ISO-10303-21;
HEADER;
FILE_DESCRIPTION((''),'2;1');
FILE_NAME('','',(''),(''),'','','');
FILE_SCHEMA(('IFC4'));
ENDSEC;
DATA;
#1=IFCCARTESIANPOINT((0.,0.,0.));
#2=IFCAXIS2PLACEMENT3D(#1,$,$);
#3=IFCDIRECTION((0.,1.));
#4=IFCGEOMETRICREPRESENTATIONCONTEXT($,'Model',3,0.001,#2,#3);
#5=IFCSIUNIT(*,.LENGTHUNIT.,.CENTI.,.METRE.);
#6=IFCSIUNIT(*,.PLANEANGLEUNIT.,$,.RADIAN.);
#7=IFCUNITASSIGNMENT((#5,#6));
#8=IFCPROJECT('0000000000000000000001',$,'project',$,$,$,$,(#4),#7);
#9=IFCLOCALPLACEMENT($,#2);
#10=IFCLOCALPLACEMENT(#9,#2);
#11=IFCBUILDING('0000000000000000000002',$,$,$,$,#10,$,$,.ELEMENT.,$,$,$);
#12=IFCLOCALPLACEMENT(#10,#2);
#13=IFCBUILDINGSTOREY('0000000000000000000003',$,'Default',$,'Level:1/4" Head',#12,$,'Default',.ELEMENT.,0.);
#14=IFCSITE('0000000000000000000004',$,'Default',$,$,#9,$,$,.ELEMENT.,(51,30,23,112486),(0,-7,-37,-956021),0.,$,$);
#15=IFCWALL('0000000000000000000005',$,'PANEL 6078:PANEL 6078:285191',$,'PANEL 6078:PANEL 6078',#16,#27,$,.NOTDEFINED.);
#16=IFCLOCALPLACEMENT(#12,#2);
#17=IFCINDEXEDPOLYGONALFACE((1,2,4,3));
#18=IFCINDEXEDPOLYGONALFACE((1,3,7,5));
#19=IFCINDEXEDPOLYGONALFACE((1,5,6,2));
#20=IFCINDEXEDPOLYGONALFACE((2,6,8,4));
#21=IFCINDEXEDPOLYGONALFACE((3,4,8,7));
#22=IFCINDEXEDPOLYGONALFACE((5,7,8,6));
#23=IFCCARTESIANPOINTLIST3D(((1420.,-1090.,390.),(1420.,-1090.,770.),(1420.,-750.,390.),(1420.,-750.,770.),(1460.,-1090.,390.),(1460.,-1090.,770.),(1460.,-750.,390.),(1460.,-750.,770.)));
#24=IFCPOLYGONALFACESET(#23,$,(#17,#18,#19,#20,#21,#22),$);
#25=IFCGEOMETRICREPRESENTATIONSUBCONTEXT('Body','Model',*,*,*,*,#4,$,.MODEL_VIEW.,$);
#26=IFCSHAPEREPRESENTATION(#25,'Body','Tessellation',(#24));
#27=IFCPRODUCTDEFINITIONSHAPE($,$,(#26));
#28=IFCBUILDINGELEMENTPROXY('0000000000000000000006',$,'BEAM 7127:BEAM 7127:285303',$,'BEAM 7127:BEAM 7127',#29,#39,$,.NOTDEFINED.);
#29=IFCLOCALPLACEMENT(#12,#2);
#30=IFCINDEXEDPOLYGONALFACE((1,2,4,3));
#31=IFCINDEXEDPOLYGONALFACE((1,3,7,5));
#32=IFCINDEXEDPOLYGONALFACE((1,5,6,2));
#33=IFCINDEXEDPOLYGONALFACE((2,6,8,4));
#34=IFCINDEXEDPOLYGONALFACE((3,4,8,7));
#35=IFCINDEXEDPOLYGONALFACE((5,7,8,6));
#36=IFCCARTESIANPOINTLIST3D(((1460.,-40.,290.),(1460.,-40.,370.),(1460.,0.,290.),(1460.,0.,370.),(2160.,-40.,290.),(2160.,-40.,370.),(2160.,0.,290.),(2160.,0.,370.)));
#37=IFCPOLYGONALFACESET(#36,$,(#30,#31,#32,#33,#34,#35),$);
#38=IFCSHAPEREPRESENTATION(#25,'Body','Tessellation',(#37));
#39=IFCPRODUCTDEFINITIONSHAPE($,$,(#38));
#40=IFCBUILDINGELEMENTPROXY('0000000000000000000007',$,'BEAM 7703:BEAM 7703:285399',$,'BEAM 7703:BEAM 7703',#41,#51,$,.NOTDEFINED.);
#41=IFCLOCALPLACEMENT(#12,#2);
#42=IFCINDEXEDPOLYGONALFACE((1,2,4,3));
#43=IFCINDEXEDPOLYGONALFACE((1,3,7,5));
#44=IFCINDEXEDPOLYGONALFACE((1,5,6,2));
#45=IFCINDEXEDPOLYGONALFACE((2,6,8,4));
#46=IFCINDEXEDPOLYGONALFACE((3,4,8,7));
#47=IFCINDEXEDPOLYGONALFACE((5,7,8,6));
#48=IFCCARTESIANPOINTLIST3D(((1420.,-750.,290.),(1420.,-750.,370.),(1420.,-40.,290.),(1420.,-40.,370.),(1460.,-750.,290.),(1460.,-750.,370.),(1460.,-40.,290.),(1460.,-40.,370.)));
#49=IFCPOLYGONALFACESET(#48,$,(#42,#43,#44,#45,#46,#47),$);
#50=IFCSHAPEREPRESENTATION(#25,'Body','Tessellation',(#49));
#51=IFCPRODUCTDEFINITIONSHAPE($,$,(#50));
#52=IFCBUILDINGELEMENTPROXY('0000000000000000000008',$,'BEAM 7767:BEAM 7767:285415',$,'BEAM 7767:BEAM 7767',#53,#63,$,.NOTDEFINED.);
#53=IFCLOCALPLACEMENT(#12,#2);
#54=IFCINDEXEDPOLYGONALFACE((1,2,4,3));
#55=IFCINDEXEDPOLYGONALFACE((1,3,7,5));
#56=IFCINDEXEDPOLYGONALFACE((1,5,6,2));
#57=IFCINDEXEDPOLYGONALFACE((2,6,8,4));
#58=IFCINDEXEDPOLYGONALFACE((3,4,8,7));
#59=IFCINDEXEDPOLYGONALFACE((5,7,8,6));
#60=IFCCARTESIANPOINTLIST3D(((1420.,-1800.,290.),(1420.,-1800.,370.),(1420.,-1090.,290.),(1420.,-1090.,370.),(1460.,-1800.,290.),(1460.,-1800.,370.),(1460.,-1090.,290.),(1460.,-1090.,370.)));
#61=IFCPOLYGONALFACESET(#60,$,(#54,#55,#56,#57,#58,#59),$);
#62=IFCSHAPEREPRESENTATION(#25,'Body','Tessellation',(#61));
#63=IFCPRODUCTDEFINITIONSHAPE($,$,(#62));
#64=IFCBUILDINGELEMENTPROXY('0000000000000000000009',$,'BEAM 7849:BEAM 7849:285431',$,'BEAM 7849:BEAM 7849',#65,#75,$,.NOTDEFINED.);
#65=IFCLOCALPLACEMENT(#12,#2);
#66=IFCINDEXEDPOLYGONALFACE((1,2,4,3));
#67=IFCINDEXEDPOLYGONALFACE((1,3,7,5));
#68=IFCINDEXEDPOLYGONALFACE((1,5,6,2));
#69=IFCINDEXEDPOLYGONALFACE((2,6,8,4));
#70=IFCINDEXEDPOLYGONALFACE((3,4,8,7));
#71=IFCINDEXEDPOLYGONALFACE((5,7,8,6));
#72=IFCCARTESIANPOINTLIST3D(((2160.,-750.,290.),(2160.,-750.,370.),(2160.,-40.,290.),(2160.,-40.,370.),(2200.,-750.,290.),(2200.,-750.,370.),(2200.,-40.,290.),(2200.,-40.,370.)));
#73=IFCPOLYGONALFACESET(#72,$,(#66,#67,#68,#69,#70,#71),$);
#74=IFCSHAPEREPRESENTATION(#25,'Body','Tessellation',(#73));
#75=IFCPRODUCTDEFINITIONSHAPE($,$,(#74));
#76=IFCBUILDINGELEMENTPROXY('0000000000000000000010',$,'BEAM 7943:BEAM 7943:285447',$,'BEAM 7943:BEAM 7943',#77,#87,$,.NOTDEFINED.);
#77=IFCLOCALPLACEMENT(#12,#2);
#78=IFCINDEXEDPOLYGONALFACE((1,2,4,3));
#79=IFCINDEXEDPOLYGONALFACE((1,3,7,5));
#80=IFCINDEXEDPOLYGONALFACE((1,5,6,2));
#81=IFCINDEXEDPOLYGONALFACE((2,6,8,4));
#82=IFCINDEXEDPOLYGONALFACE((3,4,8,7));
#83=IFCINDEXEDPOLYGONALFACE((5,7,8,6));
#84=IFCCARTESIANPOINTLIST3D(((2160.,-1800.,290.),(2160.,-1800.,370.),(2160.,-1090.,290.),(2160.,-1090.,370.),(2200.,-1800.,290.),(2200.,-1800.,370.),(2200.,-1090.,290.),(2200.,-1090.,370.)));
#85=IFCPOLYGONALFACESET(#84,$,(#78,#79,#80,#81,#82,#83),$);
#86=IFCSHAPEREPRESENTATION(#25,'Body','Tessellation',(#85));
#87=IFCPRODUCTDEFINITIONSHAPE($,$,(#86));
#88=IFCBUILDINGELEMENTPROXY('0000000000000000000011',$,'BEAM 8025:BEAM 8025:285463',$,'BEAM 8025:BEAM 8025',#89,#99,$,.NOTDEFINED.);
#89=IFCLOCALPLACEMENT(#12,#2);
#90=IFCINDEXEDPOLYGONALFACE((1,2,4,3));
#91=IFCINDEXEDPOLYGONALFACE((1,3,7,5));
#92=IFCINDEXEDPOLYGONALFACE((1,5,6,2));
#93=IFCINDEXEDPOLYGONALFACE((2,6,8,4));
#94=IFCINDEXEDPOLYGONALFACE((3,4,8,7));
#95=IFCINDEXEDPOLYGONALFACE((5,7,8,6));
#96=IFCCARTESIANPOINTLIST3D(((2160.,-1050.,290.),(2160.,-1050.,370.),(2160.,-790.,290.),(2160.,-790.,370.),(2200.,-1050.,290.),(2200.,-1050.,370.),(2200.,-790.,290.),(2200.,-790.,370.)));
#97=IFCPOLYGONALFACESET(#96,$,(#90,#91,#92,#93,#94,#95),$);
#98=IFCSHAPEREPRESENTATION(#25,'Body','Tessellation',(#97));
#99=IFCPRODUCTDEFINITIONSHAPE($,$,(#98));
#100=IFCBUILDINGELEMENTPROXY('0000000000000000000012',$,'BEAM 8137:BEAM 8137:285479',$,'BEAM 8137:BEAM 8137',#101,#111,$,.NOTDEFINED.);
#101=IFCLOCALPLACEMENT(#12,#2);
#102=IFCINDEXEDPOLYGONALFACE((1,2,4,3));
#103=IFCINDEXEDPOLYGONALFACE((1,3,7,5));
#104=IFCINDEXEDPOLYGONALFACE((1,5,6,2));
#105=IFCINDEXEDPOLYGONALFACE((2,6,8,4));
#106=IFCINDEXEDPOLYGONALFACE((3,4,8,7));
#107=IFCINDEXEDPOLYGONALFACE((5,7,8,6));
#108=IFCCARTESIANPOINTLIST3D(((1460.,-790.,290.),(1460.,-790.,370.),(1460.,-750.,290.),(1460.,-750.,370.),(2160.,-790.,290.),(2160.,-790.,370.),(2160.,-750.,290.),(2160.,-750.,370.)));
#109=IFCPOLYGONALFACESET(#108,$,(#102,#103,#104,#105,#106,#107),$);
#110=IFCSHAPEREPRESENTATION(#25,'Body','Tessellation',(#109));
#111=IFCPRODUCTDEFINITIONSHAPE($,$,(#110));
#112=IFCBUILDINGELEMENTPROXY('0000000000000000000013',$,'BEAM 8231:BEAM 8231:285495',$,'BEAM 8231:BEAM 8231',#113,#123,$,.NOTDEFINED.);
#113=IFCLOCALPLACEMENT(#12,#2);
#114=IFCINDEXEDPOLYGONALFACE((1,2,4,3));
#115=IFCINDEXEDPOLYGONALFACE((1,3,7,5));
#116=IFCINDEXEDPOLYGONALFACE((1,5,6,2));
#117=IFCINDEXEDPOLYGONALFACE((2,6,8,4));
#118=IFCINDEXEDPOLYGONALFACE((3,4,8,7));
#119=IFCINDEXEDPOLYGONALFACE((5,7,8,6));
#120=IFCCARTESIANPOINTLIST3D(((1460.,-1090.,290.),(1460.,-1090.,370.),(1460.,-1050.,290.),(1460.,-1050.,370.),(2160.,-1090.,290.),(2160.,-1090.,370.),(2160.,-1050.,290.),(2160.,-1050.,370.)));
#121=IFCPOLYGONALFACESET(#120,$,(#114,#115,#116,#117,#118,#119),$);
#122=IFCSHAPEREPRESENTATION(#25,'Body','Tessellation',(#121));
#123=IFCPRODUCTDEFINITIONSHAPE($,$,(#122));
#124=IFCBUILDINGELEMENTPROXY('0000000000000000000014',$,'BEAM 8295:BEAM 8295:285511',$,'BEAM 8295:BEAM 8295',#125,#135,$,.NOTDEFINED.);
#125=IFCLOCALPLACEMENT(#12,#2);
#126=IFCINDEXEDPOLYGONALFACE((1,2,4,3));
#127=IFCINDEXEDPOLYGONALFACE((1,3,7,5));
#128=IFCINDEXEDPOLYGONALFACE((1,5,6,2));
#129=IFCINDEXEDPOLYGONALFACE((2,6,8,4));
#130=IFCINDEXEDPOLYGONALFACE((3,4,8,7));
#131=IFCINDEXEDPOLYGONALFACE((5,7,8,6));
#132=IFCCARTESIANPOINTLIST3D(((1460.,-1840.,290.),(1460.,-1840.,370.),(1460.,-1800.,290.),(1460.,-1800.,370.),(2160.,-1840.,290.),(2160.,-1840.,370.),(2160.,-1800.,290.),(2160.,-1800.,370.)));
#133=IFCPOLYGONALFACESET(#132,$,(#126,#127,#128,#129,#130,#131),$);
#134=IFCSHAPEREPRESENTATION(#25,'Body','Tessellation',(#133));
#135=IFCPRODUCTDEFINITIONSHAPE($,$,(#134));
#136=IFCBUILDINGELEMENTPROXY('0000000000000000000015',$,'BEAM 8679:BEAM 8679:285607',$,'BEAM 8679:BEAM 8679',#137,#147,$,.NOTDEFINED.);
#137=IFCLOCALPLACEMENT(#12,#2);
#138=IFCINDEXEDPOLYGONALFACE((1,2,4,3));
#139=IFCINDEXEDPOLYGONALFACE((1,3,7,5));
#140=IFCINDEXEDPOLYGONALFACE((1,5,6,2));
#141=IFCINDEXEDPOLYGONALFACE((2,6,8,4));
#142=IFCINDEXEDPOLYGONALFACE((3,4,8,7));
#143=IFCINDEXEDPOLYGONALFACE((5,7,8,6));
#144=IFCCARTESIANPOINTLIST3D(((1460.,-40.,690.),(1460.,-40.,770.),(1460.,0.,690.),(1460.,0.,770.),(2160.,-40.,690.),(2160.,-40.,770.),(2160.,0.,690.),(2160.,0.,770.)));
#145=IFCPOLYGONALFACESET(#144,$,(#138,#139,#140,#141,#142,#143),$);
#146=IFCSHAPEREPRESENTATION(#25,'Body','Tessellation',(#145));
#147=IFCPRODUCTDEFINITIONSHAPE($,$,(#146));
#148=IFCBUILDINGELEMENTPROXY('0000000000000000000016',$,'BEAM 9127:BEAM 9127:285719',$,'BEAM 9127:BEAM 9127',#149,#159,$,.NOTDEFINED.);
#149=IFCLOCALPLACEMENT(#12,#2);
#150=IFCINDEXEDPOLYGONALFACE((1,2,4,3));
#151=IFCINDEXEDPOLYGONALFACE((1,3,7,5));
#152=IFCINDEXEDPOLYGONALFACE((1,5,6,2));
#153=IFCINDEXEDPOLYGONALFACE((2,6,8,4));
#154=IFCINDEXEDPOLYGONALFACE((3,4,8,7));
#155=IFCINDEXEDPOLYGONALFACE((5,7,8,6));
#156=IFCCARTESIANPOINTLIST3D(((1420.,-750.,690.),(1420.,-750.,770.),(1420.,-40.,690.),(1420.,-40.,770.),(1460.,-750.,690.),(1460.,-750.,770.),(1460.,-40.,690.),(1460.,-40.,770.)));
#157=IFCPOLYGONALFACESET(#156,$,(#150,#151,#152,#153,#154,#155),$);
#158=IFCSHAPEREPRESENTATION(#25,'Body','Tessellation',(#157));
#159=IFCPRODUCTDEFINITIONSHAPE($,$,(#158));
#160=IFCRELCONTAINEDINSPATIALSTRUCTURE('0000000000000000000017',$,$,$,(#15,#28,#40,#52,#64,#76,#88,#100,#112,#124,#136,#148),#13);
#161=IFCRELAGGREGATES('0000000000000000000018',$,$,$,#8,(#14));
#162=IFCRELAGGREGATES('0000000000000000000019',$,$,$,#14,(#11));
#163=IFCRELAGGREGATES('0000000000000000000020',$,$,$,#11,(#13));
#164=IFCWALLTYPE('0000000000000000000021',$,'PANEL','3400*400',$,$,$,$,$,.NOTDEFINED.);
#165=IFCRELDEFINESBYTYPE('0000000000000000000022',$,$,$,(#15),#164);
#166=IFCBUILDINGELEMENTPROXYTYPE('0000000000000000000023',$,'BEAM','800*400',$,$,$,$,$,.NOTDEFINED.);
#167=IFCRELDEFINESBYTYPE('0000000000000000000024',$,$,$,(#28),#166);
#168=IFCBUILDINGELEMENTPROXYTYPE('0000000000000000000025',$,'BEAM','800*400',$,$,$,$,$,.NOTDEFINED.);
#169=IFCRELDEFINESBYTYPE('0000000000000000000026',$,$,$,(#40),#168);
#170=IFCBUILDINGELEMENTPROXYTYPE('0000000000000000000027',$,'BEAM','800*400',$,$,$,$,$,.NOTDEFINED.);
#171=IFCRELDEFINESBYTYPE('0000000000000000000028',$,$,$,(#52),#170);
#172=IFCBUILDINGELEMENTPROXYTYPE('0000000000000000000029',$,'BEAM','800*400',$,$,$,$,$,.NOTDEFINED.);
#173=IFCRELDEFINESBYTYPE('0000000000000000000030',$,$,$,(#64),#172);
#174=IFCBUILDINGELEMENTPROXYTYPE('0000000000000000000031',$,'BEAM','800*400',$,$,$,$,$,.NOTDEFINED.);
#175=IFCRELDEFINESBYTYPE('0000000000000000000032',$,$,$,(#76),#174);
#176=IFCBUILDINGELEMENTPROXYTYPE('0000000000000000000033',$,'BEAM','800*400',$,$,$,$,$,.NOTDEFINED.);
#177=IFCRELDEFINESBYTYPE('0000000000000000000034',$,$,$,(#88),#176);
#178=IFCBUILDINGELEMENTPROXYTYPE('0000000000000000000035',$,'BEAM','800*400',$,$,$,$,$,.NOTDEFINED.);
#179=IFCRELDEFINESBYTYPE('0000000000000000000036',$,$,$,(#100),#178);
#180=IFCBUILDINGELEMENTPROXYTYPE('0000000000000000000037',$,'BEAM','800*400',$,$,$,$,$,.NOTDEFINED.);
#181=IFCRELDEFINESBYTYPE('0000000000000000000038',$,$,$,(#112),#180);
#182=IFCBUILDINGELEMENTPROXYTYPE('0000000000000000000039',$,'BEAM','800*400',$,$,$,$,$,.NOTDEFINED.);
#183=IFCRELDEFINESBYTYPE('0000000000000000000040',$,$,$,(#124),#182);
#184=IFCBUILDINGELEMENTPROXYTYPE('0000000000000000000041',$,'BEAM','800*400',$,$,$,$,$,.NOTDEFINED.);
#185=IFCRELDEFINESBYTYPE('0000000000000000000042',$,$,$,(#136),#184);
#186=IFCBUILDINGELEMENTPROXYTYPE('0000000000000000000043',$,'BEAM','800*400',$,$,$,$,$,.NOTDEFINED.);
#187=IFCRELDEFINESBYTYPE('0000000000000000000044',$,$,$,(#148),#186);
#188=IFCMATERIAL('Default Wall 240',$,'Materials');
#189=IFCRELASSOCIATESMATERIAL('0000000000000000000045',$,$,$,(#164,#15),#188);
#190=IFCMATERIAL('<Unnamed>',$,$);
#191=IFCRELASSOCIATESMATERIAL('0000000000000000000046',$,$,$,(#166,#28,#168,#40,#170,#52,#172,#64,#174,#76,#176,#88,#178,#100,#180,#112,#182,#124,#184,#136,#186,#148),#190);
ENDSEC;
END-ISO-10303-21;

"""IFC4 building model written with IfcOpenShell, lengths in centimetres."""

from ifc_helpers import new_model, si_unit, direction, frame, frame_2d, origin, origin_2d_with_axis, place, context, subcontext, project, spatial, rectangle, extrude, source, transform, mapped, material, type_object, type_shapes, element, save


model = new_model("IFC4")

# Units and contexts
model_context = context("Model", 3, precision=0.001, world=origin(), true_north=direction((0.0, 1.0)))
body_context = subcontext(model_context, "Body", "Model", "MODEL_VIEW")
ifc_project = project(units=[si_unit("LENGTHUNIT", "METRE", prefix="CENTI"), si_unit("PLANEANGLEUNIT", "RADIAN")], contexts=[model_context])

# Site, building, storey
site_placement = place(None, origin())
site = spatial("IfcSite", under=ifc_project, at=site_placement, Name="Default", CompositionType="ELEMENT", RefLatitude=(51, 30, 23, 112486), RefLongitude=(0, -7, -37, -956021), RefElevation=0.0)
building_placement = place(site_placement, origin())
building = spatial("IfcBuilding", under=site, at=building_placement, CompositionType="ELEMENT")
storey_placement = place(building_placement, origin())
storey = spatial("IfcBuildingStorey", under=building, at=storey_placement, Name="Default", ObjectType="Level:1/4\" Head", LongName="Default", CompositionType="ELEMENT", Elevation=0.0)

# Wall
ifc_material_1 = material(Name="Default Wall 240", Category="Materials")
wall_type = type_object("IfcWallType", Name="PANEL", Description="3400*400", PredefinedType="NOTDEFINED", material=ifc_material_1)
wall_placement = place(storey_placement, frame((1420.0, -1090.0, 390.0), z_axis=(0.0, 0.0, 1.0), x_axis=(0.0, 1.0, 0.0)))
element("IfcWall", 1, at=wall_placement, inside=storey, type_object=wall_type, material=ifc_material_1, Name="PANEL 6078:PANEL 6078:285191", ObjectType="PANEL 6078:PANEL 6078", PredefinedType="NOTDEFINED", context=body_context, shape_type="SweptSolid", body=[
    extrude(rectangle(XDim=340.0, YDim=40.0, at=frame_2d((0.0, 0.0), x_axis=(1.0, 0.0))), frame((170.0, -20.0, 0.0)), (0.0, 0.0, 1.0), 380.0),
])

# Building element proxies
ifc_material_2 = material(Name="<Unnamed>")
building_element_proxy_type_1 = type_object("IfcBuildingElementProxyType", Name="BEAM", Description="800*400", PredefinedType="NOTDEFINED", material=ifc_material_2)
shared_shape_1 = source(origin(), body_context, "Body", "SweptSolid", [
    extrude(rectangle(XDim=40.0, YDim=700.0, at=origin_2d_with_axis()), frame((350.0, 20.0, 0.0), z_axis=(0.0, 0.0, 1.0), x_axis=(0.0, 1.0, 0.0)), (0.0, 0.0, 1.0), 80.0),
])
type_shapes(building_element_proxy_type_1, [shared_shape_1])
proxy_1_placement = place(storey_placement, frame((1460.0, -40.0, 290.0)))
element("IfcBuildingElementProxy", 2, at=proxy_1_placement, inside=storey, type_object=building_element_proxy_type_1, material=ifc_material_2, Name="BEAM 7127:BEAM 7127:285303", ObjectType="BEAM 7127:BEAM 7127", PredefinedType="NOTDEFINED", context=body_context, shape_type="MappedRepresentation", body=[
    mapped(shared_shape_1, transform((0.0, 0.0, 0.0), scale=1.0)),
])
building_element_proxy_type_2 = type_object("IfcBuildingElementProxyType", Name="BEAM", Description="800*400", PredefinedType="NOTDEFINED", material=ifc_material_2)
shared_shape_2 = source(origin(), body_context, "Body", "SweptSolid", [
    extrude(rectangle(XDim=40.0, YDim=710.0, at=frame_2d((0.0, 0.0), x_axis=(1.0, 0.0))), frame((20.0, 355.0, 0.0)), (0.0, 0.0, 1.0), 80.0),
])
type_shapes(building_element_proxy_type_2, [shared_shape_2])
proxy_2_placement = place(storey_placement, frame((1420.0, -750.0, 290.0)))
element("IfcBuildingElementProxy", 3, at=proxy_2_placement, inside=storey, type_object=building_element_proxy_type_2, material=ifc_material_2, Name="BEAM 7703:BEAM 7703:285399", ObjectType="BEAM 7703:BEAM 7703", PredefinedType="NOTDEFINED", context=body_context, shape_type="MappedRepresentation", body=[
    mapped(shared_shape_2, transform((0.0, 0.0, 0.0), scale=1.0)),
])
building_element_proxy_type_3 = type_object("IfcBuildingElementProxyType", Name="BEAM", Description="800*400", PredefinedType="NOTDEFINED", material=ifc_material_2)
shared_shape_3 = source(origin(), body_context, "Body", "SweptSolid", [
    extrude(rectangle(XDim=40.0, YDim=710.0, at=frame_2d((0.0, 0.0), x_axis=(1.0, 0.0))), frame((20.0, 355.0, 0.0)), (0.0, 0.0, 1.0), 80.0),
])
type_shapes(building_element_proxy_type_3, [shared_shape_3])
proxy_3_placement = place(storey_placement, frame((1420.0, -1800.0, 290.0)))
element("IfcBuildingElementProxy", 4, at=proxy_3_placement, inside=storey, type_object=building_element_proxy_type_3, material=ifc_material_2, Name="BEAM 7767:BEAM 7767:285415", ObjectType="BEAM 7767:BEAM 7767", PredefinedType="NOTDEFINED", context=body_context, shape_type="MappedRepresentation", body=[
    mapped(shared_shape_3, transform((0.0, 0.0, 0.0), scale=1.0)),
])
building_element_proxy_type_4 = type_object("IfcBuildingElementProxyType", Name="BEAM", Description="800*400", PredefinedType="NOTDEFINED", material=ifc_material_2)
shared_shape_4 = source(origin(), body_context, "Body", "SweptSolid", [
    extrude(rectangle(XDim=40.0, YDim=710.0, at=frame_2d((0.0, 0.0), x_axis=(1.0, 0.0))), frame((20.0, 355.0, 0.0)), (0.0, 0.0, 1.0), 80.0),
])
type_shapes(building_element_proxy_type_4, [shared_shape_4])
proxy_4_placement = place(storey_placement, frame((2160.0, -750.0, 290.0)))
element("IfcBuildingElementProxy", 5, at=proxy_4_placement, inside=storey, type_object=building_element_proxy_type_4, material=ifc_material_2, Name="BEAM 7849:BEAM 7849:285431", ObjectType="BEAM 7849:BEAM 7849", PredefinedType="NOTDEFINED", context=body_context, shape_type="MappedRepresentation", body=[
    mapped(shared_shape_4, transform((0.0, 0.0, 0.0), scale=1.0)),
])
building_element_proxy_type_5 = type_object("IfcBuildingElementProxyType", Name="BEAM", Description="800*400", PredefinedType="NOTDEFINED", material=ifc_material_2)
shared_shape_5 = source(origin(), body_context, "Body", "SweptSolid", [
    extrude(rectangle(XDim=40.0, YDim=710.0, at=frame_2d((0.0, 0.0), x_axis=(1.0, 0.0))), frame((20.0, 355.0, 0.0)), (0.0, 0.0, 1.0), 80.0),
])
type_shapes(building_element_proxy_type_5, [shared_shape_5])
proxy_5_placement = place(storey_placement, frame((2160.0, -1800.0, 290.0)))
element("IfcBuildingElementProxy", 6, at=proxy_5_placement, inside=storey, type_object=building_element_proxy_type_5, material=ifc_material_2, Name="BEAM 7943:BEAM 7943:285447", ObjectType="BEAM 7943:BEAM 7943", PredefinedType="NOTDEFINED", context=body_context, shape_type="MappedRepresentation", body=[
    mapped(shared_shape_5, transform((0.0, 0.0, 0.0), scale=1.0)),
])
building_element_proxy_type_6 = type_object("IfcBuildingElementProxyType", Name="BEAM", Description="800*400", PredefinedType="NOTDEFINED", material=ifc_material_2)
shared_shape_6 = source(origin(), body_context, "Body", "SweptSolid", [
    extrude(rectangle(XDim=40.0, YDim=260.0, at=frame_2d((0.0, 0.0), x_axis=(1.0, 0.0))), frame((20.0, 130.0, 0.0)), (0.0, 0.0, 1.0), 80.0),
])
type_shapes(building_element_proxy_type_6, [shared_shape_6])
proxy_6_placement = place(storey_placement, frame((2160.0, -1050.0, 290.0)))
element("IfcBuildingElementProxy", 7, at=proxy_6_placement, inside=storey, type_object=building_element_proxy_type_6, material=ifc_material_2, Name="BEAM 8025:BEAM 8025:285463", ObjectType="BEAM 8025:BEAM 8025", PredefinedType="NOTDEFINED", context=body_context, shape_type="MappedRepresentation", body=[
    mapped(shared_shape_6, transform((0.0, 0.0, 0.0), scale=1.0)),
])
building_element_proxy_type_7 = type_object("IfcBuildingElementProxyType", Name="BEAM", Description="800*400", PredefinedType="NOTDEFINED", material=ifc_material_2)
shared_shape_7 = source(origin(), body_context, "Body", "SweptSolid", [
    extrude(rectangle(XDim=40.0, YDim=700.0, at=origin_2d_with_axis()), frame((350.0, 20.0, 0.0), z_axis=(0.0, 0.0, 1.0), x_axis=(0.0, 1.0, 0.0)), (0.0, 0.0, 1.0), 80.0),
])
type_shapes(building_element_proxy_type_7, [shared_shape_7])
proxy_7_placement = place(storey_placement, frame((1460.0, -790.0, 290.0)))
element("IfcBuildingElementProxy", 8, at=proxy_7_placement, inside=storey, type_object=building_element_proxy_type_7, material=ifc_material_2, Name="BEAM 8137:BEAM 8137:285479", ObjectType="BEAM 8137:BEAM 8137", PredefinedType="NOTDEFINED", context=body_context, shape_type="MappedRepresentation", body=[
    mapped(shared_shape_7, transform((0.0, 0.0, 0.0), scale=1.0)),
])
building_element_proxy_type_8 = type_object("IfcBuildingElementProxyType", Name="BEAM", Description="800*400", PredefinedType="NOTDEFINED", material=ifc_material_2)
shared_shape_8 = source(origin(), body_context, "Body", "SweptSolid", [
    extrude(rectangle(XDim=40.0, YDim=700.0, at=origin_2d_with_axis()), frame((350.0, 20.0, 0.0), z_axis=(0.0, 0.0, 1.0), x_axis=(0.0, 1.0, 0.0)), (0.0, 0.0, 1.0), 80.0),
])
type_shapes(building_element_proxy_type_8, [shared_shape_8])
proxy_8_placement = place(storey_placement, frame((1460.0, -1090.0, 290.0)))
element("IfcBuildingElementProxy", 9, at=proxy_8_placement, inside=storey, type_object=building_element_proxy_type_8, material=ifc_material_2, Name="BEAM 8231:BEAM 8231:285495", ObjectType="BEAM 8231:BEAM 8231", PredefinedType="NOTDEFINED", context=body_context, shape_type="MappedRepresentation", body=[
    mapped(shared_shape_8, transform((0.0, 0.0, 0.0), scale=1.0)),
])
building_element_proxy_type_9 = type_object("IfcBuildingElementProxyType", Name="BEAM", Description="800*400", PredefinedType="NOTDEFINED", material=ifc_material_2)
shared_shape_9 = source(origin(), body_context, "Body", "SweptSolid", [
    extrude(rectangle(XDim=40.0, YDim=700.0, at=origin_2d_with_axis()), frame((350.0, 20.0, 0.0), z_axis=(0.0, 0.0, 1.0), x_axis=(0.0, 1.0, 0.0)), (0.0, 0.0, 1.0), 80.0),
])
type_shapes(building_element_proxy_type_9, [shared_shape_9])
proxy_9_placement = place(storey_placement, frame((1460.0, -1840.0, 290.0)))
element("IfcBuildingElementProxy", 10, at=proxy_9_placement, inside=storey, type_object=building_element_proxy_type_9, material=ifc_material_2, Name="BEAM 8295:BEAM 8295:285511", ObjectType="BEAM 8295:BEAM 8295", PredefinedType="NOTDEFINED", context=body_context, shape_type="MappedRepresentation", body=[
    mapped(shared_shape_9, transform((0.0, 0.0, 0.0), scale=1.0)),
])
building_element_proxy_type_10 = type_object("IfcBuildingElementProxyType", Name="BEAM", Description="800*400", PredefinedType="NOTDEFINED", material=ifc_material_2)
shared_shape_10 = source(origin(), body_context, "Body", "SweptSolid", [
    extrude(rectangle(XDim=40.0, YDim=700.0, at=origin_2d_with_axis()), frame((350.0, 20.0, 0.0), z_axis=(0.0, 0.0, 1.0), x_axis=(0.0, 1.0, 0.0)), (0.0, 0.0, 1.0), 80.0),
])
type_shapes(building_element_proxy_type_10, [shared_shape_10])
proxy_10_placement = place(storey_placement, frame((1460.0, -40.0, 690.0)))
element("IfcBuildingElementProxy", 11, at=proxy_10_placement, inside=storey, type_object=building_element_proxy_type_10, material=ifc_material_2, Name="BEAM 8679:BEAM 8679:285607", ObjectType="BEAM 8679:BEAM 8679", PredefinedType="NOTDEFINED", context=body_context, shape_type="MappedRepresentation", body=[
    mapped(shared_shape_10, transform((0.0, 0.0, 0.0), scale=1.0)),
])
building_element_proxy_type_11 = type_object("IfcBuildingElementProxyType", Name="BEAM", Description="800*400", PredefinedType="NOTDEFINED", material=ifc_material_2)
shared_shape_11 = source(origin(), body_context, "Body", "SweptSolid", [
    extrude(rectangle(XDim=40.0, YDim=710.0, at=frame_2d((0.0, 0.0), x_axis=(1.0, 0.0))), frame((20.0, 355.0, 0.0)), (0.0, 0.0, 1.0), 80.0),
])
type_shapes(building_element_proxy_type_11, [shared_shape_11])
proxy_11_placement = place(storey_placement, frame((1420.0, -750.0, 690.0)))
element("IfcBuildingElementProxy", 12, at=proxy_11_placement, inside=storey, type_object=building_element_proxy_type_11, material=ifc_material_2, Name="BEAM 9127:BEAM 9127:285719", ObjectType="BEAM 9127:BEAM 9127", PredefinedType="NOTDEFINED", context=body_context, shape_type="MappedRepresentation", body=[
    mapped(shared_shape_11, transform((0.0, 0.0, 0.0), scale=1.0)),
])

save(model, "model.ifc")
